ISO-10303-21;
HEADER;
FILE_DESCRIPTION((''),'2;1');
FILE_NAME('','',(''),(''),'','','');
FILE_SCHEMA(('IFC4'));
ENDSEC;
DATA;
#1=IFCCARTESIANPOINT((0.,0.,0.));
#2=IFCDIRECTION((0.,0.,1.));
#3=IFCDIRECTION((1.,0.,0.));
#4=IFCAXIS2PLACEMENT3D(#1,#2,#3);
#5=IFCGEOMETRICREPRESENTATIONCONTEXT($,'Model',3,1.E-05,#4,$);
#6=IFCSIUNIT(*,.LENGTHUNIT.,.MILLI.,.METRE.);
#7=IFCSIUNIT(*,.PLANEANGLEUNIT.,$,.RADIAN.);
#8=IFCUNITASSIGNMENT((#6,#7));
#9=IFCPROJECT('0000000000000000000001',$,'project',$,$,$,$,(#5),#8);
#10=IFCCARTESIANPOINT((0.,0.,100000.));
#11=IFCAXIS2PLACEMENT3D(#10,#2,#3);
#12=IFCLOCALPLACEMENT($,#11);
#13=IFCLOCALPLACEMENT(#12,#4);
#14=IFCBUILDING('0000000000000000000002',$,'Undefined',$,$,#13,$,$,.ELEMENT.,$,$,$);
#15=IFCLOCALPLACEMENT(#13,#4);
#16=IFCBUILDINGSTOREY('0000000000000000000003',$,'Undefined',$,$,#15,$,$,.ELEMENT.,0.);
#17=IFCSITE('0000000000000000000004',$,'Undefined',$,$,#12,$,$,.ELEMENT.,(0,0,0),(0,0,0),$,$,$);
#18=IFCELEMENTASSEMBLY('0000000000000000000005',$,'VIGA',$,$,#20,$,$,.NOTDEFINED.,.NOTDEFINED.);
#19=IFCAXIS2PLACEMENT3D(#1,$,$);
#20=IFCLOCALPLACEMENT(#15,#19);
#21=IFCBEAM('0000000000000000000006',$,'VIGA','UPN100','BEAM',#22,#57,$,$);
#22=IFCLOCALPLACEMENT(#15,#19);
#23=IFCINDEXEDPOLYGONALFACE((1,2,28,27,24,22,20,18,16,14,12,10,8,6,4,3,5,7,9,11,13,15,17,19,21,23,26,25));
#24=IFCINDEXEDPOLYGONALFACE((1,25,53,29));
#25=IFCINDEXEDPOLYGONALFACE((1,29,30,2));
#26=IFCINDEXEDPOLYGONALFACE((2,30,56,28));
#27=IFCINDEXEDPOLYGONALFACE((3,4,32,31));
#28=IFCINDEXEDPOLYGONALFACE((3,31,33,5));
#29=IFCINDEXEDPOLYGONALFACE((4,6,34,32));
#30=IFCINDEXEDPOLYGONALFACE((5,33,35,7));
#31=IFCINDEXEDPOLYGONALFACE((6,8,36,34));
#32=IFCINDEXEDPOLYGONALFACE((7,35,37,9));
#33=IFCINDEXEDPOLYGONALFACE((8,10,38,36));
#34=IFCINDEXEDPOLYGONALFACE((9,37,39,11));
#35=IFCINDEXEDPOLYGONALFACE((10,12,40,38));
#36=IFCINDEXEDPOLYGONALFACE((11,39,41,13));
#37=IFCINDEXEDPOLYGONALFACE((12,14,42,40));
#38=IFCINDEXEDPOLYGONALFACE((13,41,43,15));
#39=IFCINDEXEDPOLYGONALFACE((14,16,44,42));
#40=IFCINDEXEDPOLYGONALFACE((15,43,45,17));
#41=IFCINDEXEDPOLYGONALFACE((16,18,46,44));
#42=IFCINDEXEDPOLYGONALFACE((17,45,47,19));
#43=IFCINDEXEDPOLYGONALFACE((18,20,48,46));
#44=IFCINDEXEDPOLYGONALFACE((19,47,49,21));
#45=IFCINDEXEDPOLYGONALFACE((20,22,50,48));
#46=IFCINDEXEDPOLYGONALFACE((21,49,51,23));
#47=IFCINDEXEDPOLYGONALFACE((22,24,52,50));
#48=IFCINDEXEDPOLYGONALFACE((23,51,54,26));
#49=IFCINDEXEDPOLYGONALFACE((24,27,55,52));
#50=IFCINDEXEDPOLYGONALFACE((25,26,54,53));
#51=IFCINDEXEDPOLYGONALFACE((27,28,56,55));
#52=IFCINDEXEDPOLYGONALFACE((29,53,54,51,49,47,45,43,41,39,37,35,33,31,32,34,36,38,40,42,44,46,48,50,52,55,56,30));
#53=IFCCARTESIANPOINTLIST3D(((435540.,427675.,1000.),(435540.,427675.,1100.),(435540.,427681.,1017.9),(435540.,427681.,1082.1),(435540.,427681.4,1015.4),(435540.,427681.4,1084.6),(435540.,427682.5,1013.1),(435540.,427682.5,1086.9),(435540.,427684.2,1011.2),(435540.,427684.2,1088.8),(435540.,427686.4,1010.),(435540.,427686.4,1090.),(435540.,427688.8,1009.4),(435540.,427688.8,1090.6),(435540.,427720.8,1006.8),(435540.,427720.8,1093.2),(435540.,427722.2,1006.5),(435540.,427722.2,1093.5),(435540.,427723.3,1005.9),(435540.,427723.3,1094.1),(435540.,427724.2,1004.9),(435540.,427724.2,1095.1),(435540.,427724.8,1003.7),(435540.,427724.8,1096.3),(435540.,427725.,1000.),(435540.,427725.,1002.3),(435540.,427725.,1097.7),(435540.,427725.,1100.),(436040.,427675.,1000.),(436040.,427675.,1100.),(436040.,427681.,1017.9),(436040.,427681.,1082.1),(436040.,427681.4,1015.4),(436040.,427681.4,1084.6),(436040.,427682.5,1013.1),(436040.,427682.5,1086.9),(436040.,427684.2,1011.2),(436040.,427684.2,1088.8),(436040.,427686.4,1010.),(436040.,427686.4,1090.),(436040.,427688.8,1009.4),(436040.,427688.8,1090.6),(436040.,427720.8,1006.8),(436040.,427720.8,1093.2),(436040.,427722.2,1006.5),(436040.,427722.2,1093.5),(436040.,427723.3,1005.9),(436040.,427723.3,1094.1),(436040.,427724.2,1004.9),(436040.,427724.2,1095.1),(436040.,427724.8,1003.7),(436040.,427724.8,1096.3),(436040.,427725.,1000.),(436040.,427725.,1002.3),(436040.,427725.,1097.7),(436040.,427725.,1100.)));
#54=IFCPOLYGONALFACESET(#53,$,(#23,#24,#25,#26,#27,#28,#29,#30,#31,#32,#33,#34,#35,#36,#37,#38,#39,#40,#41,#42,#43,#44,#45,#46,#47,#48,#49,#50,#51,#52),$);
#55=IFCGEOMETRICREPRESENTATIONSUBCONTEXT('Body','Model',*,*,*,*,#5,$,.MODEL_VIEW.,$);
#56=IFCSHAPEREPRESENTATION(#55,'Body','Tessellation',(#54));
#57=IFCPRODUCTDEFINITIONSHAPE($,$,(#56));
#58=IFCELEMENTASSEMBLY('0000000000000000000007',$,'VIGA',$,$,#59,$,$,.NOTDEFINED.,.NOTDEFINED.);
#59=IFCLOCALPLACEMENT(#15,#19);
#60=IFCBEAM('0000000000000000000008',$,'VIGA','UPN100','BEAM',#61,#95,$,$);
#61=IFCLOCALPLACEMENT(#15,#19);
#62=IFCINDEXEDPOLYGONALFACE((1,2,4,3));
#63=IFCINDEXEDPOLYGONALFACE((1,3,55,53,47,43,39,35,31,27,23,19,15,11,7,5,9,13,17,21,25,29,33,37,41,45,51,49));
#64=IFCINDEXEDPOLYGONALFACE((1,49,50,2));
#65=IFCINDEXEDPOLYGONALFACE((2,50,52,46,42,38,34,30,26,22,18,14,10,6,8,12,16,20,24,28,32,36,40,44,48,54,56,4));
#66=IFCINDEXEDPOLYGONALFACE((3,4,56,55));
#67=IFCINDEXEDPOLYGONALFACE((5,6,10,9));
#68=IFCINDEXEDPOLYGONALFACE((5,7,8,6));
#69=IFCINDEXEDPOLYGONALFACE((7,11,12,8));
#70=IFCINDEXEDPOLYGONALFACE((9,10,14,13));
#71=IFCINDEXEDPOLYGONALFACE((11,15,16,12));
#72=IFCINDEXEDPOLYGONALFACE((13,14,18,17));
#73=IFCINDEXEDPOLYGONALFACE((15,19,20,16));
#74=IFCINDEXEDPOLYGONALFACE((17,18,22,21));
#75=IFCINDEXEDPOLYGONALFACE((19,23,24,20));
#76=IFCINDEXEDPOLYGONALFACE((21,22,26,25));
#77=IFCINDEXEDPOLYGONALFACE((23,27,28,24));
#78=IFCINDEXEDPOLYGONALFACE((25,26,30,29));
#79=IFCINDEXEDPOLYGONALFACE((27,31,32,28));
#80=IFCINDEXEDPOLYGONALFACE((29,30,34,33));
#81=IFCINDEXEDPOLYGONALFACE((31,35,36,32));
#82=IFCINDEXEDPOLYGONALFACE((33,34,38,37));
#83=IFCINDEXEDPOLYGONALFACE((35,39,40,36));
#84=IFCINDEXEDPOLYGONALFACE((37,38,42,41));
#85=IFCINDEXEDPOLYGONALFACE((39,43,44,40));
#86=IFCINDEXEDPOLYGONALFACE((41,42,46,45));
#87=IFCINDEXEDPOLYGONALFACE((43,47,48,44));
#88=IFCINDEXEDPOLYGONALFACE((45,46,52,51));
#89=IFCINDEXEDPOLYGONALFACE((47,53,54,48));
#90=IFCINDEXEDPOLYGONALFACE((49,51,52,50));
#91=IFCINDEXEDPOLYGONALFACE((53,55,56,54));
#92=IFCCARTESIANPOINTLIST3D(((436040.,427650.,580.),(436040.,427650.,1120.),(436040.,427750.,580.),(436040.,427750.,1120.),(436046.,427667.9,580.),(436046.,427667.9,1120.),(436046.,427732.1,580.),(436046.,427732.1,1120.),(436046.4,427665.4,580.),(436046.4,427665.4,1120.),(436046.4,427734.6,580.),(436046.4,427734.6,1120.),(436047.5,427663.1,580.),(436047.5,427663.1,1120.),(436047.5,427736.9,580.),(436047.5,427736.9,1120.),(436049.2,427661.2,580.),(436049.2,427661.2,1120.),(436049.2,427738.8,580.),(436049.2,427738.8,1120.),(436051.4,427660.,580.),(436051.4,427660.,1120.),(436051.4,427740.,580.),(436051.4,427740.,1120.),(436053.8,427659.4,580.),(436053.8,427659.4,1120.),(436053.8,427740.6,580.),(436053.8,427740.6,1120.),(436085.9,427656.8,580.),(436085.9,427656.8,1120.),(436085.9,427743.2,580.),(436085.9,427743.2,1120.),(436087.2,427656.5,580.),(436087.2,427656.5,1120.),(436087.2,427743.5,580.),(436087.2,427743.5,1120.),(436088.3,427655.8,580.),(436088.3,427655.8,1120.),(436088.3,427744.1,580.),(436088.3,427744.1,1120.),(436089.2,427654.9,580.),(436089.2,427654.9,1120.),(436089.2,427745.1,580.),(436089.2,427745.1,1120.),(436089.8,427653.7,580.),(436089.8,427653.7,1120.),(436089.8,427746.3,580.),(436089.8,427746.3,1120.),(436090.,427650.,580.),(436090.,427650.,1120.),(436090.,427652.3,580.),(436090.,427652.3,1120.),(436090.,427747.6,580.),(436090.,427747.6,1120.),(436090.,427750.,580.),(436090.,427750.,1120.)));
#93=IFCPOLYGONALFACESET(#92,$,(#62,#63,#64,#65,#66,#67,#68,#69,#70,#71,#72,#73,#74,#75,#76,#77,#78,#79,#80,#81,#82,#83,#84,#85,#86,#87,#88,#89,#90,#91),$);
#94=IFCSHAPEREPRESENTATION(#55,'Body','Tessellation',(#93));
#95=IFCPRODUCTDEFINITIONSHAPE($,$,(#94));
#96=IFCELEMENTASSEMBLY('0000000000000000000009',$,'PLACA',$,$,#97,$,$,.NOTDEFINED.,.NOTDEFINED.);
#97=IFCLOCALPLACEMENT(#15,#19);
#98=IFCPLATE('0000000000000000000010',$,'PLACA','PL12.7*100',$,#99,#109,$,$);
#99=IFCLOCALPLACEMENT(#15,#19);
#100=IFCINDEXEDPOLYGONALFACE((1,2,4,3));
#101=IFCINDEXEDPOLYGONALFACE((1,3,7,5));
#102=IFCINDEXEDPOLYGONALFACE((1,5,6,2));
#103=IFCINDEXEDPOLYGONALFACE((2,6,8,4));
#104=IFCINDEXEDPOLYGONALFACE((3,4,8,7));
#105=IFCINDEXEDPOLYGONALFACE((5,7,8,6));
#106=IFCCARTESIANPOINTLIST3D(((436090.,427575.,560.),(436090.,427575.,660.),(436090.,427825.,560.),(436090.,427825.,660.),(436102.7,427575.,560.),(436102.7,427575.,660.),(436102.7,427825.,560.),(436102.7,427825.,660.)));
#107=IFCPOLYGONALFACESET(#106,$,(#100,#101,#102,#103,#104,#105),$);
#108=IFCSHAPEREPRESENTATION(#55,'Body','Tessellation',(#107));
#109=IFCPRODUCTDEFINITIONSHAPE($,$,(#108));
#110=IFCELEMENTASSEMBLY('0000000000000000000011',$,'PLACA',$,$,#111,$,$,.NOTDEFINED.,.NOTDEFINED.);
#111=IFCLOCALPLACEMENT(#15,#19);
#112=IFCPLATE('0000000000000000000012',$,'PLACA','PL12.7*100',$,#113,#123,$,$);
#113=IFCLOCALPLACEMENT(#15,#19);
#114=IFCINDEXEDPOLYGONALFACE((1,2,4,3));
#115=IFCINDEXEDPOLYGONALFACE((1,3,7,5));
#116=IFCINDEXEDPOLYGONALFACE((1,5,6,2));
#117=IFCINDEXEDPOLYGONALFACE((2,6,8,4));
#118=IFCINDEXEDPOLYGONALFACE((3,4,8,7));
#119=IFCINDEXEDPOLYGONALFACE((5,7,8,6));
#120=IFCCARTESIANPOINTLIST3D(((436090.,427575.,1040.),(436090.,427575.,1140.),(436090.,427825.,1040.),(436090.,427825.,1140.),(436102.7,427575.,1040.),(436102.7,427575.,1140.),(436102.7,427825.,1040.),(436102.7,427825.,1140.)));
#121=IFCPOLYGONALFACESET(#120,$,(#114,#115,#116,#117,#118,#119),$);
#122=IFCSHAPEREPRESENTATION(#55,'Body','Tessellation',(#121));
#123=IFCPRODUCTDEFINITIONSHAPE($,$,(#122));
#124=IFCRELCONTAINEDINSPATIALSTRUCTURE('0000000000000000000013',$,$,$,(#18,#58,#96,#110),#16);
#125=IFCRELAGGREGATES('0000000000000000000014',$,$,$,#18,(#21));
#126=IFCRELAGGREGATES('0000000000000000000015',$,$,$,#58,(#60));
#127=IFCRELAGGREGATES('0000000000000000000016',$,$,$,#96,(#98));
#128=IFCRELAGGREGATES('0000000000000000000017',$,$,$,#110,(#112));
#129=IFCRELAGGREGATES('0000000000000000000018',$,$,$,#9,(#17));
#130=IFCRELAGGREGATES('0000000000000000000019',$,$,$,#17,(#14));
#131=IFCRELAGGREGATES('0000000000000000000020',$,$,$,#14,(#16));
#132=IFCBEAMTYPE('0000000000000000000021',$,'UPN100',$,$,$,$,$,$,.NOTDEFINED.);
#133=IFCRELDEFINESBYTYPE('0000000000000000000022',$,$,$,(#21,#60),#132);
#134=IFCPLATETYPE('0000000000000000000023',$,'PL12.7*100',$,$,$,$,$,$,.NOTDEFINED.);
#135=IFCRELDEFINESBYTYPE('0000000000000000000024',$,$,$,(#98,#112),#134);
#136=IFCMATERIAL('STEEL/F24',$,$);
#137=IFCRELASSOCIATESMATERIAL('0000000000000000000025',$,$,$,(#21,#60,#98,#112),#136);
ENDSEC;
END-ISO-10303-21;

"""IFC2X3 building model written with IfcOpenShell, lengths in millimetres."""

from ifc_helpers import new_model, si_unit, frame, origin_with_axes, origin_2d_with_axis, place, context, subcontext, project, spatial, polyline, u_section, outline, extrude, material, type_object, element, aggregate, save


model = new_model("IFC2X3")

# Units and contexts
model_context = context("Model", 3, precision=1e-05, world=origin_with_axes())
body_context = subcontext(model_context, "Body", "Model", "MODEL_VIEW")
ifc_project = project(units=[si_unit("LENGTHUNIT", "METRE", prefix="MILLI"), si_unit("PLANEANGLEUNIT", "RADIAN")], contexts=[model_context])

# Site, building, storey
site_placement = place(None, frame((0.0, 0.0, 100000.0), z_axis=(0.0, 0.0, 1.0), x_axis=(1.0, 0.0, 0.0)))
site = spatial("IfcSite", under=ifc_project, at=site_placement, Name="Undefined", CompositionType="ELEMENT", RefLatitude=(0, 0, 0), RefLongitude=(0, 0, 0))
building_placement = place(site_placement, origin_with_axes())
building = spatial("IfcBuilding", under=site, at=building_placement, Name="Undefined", CompositionType="ELEMENT")
storey_placement = place(building_placement, origin_with_axes())
storey = spatial("IfcBuildingStorey", under=building, at=storey_placement, Name="Undefined", CompositionType="ELEMENT", Elevation=0.0)

# Element assemblies, beams
ifc_material_1 = material(Name="STEEL/F24")
beam_type = type_object("IfcBeamType", Name="UPN100", PredefinedType="NOTDEFINED")
assembly_1_placement = place(storey_placement, origin_with_axes())
assembly_1 = element("IfcElementAssembly", 1, at=assembly_1_placement, inside=storey, Name="VIGA", AssemblyPlace="NOTDEFINED", PredefinedType="NOTDEFINED")
beam_1_placement = place(assembly_1_placement, frame((436040.0, 427700.0, 1050.0), z_axis=(0.0, 0.0, 1.0), x_axis=(-1.0, 0.0, 0.0)))
beam_1 = element("IfcBeam", 2, at=beam_1_placement, type_object=beam_type, material=ifc_material_1, Name="VIGA", Description="UPN100", ObjectType="BEAM", context=body_context, shape_type="SweptSolid", body=[
    extrude(u_section(Depth=100.0, FlangeWidth=50.0, WebThickness=6.0, FlangeThickness=8.5, FilletRadius=8.5, EdgeRadius=4.5, FlangeSlope=0.07983, at=origin_2d_with_axis()), frame((500.0, 0.0, 0.0), z_axis=(-1.0, 0.0, 0.0), x_axis=(0.0, -1.0, 0.0)), (0.0, 0.0, 1.0), 500.0),
])
aggregate(assembly_1, [beam_1])
assembly_2_placement = place(storey_placement, origin_with_axes())
assembly_2 = element("IfcElementAssembly", 3, at=assembly_2_placement, inside=storey, Name="VIGA", AssemblyPlace="NOTDEFINED", PredefinedType="NOTDEFINED")
beam_2_placement = place(assembly_2_placement, frame((436065.0, 427700.0, 1120.0), z_axis=(0.0, 1.0, 0.0), x_axis=(0.0, 0.0, -1.0)))
beam_2 = element("IfcBeam", 4, at=beam_2_placement, type_object=beam_type, material=ifc_material_1, Name="VIGA", Description="UPN100", ObjectType="BEAM", context=body_context, shape_type="SweptSolid", body=[
    extrude(u_section(Depth=100.0, FlangeWidth=50.0, WebThickness=6.0, FlangeThickness=8.5, FilletRadius=8.5, EdgeRadius=4.5, FlangeSlope=0.07983, at=origin_2d_with_axis()), frame((540.0, 0.0, 0.0), z_axis=(-1.0, 0.0, 0.0), x_axis=(0.0, -1.0, 0.0)), (0.0, 0.0, 1.0), 540.0),
])
aggregate(assembly_2, [beam_2])

# Element assemblies, plates
assembly_3_placement = place(storey_placement, origin_with_axes())
assembly_3 = element("IfcElementAssembly", 5, at=assembly_3_placement, inside=storey, Name="PLACA", AssemblyPlace="NOTDEFINED", PredefinedType="NOTDEFINED")
plate_type = type_object("IfcPlateType", Name="PL12.7*100", PredefinedType="NOTDEFINED")
plate_1_placement = place(assembly_3_placement, frame((436096.4, 427825.0, 660.0), z_axis=(1.0, 0.0, 0.0), x_axis=(0.0, -1.0, 0.0)))
plate_1 = element("IfcPlate", 6, at=plate_1_placement, type_object=plate_type, material=ifc_material_1, Name="PLACA", Description="PL12.7*100", context=body_context, shape_type="SweptSolid", body=[
    extrude(outline(polyline([(0.0, 0.0), (250.0, 0.0), (250.0, 100.0), (0.0, 100.0), (0.0, 0.0)])), frame((0.0, 0.0, -6.3), z_axis=(0.0, 0.0, 1.0), x_axis=(1.0, 0.0, 0.0)), (0.0, 0.0, 1.0), 12.7),
])
aggregate(assembly_3, [plate_1])
assembly_4_placement = place(storey_placement, origin_with_axes())
assembly_4 = element("IfcElementAssembly", 7, at=assembly_4_placement, inside=storey, Name="PLACA", AssemblyPlace="NOTDEFINED", PredefinedType="NOTDEFINED")
plate_2_placement = place(assembly_4_placement, frame((436096.4, 427825.0, 1140.0), z_axis=(1.0, 0.0, 0.0), x_axis=(0.0, -1.0, 0.0)))
plate_2 = element("IfcPlate", 8, at=plate_2_placement, type_object=plate_type, material=ifc_material_1, Name="PLACA", Description="PL12.7*100", context=body_context, shape_type="SweptSolid", body=[
    extrude(outline(polyline([(0.0, 0.0), (250.0, 0.0), (250.0, 100.0), (0.0, 100.0), (0.0, 0.0)])), frame((0.0, 0.0, -6.3), z_axis=(0.0, 0.0, 1.0), x_axis=(1.0, 0.0, 0.0)), (0.0, 0.0, 1.0), 12.7),
])
aggregate(assembly_4, [plate_2])

save(model, "model.ifc")
